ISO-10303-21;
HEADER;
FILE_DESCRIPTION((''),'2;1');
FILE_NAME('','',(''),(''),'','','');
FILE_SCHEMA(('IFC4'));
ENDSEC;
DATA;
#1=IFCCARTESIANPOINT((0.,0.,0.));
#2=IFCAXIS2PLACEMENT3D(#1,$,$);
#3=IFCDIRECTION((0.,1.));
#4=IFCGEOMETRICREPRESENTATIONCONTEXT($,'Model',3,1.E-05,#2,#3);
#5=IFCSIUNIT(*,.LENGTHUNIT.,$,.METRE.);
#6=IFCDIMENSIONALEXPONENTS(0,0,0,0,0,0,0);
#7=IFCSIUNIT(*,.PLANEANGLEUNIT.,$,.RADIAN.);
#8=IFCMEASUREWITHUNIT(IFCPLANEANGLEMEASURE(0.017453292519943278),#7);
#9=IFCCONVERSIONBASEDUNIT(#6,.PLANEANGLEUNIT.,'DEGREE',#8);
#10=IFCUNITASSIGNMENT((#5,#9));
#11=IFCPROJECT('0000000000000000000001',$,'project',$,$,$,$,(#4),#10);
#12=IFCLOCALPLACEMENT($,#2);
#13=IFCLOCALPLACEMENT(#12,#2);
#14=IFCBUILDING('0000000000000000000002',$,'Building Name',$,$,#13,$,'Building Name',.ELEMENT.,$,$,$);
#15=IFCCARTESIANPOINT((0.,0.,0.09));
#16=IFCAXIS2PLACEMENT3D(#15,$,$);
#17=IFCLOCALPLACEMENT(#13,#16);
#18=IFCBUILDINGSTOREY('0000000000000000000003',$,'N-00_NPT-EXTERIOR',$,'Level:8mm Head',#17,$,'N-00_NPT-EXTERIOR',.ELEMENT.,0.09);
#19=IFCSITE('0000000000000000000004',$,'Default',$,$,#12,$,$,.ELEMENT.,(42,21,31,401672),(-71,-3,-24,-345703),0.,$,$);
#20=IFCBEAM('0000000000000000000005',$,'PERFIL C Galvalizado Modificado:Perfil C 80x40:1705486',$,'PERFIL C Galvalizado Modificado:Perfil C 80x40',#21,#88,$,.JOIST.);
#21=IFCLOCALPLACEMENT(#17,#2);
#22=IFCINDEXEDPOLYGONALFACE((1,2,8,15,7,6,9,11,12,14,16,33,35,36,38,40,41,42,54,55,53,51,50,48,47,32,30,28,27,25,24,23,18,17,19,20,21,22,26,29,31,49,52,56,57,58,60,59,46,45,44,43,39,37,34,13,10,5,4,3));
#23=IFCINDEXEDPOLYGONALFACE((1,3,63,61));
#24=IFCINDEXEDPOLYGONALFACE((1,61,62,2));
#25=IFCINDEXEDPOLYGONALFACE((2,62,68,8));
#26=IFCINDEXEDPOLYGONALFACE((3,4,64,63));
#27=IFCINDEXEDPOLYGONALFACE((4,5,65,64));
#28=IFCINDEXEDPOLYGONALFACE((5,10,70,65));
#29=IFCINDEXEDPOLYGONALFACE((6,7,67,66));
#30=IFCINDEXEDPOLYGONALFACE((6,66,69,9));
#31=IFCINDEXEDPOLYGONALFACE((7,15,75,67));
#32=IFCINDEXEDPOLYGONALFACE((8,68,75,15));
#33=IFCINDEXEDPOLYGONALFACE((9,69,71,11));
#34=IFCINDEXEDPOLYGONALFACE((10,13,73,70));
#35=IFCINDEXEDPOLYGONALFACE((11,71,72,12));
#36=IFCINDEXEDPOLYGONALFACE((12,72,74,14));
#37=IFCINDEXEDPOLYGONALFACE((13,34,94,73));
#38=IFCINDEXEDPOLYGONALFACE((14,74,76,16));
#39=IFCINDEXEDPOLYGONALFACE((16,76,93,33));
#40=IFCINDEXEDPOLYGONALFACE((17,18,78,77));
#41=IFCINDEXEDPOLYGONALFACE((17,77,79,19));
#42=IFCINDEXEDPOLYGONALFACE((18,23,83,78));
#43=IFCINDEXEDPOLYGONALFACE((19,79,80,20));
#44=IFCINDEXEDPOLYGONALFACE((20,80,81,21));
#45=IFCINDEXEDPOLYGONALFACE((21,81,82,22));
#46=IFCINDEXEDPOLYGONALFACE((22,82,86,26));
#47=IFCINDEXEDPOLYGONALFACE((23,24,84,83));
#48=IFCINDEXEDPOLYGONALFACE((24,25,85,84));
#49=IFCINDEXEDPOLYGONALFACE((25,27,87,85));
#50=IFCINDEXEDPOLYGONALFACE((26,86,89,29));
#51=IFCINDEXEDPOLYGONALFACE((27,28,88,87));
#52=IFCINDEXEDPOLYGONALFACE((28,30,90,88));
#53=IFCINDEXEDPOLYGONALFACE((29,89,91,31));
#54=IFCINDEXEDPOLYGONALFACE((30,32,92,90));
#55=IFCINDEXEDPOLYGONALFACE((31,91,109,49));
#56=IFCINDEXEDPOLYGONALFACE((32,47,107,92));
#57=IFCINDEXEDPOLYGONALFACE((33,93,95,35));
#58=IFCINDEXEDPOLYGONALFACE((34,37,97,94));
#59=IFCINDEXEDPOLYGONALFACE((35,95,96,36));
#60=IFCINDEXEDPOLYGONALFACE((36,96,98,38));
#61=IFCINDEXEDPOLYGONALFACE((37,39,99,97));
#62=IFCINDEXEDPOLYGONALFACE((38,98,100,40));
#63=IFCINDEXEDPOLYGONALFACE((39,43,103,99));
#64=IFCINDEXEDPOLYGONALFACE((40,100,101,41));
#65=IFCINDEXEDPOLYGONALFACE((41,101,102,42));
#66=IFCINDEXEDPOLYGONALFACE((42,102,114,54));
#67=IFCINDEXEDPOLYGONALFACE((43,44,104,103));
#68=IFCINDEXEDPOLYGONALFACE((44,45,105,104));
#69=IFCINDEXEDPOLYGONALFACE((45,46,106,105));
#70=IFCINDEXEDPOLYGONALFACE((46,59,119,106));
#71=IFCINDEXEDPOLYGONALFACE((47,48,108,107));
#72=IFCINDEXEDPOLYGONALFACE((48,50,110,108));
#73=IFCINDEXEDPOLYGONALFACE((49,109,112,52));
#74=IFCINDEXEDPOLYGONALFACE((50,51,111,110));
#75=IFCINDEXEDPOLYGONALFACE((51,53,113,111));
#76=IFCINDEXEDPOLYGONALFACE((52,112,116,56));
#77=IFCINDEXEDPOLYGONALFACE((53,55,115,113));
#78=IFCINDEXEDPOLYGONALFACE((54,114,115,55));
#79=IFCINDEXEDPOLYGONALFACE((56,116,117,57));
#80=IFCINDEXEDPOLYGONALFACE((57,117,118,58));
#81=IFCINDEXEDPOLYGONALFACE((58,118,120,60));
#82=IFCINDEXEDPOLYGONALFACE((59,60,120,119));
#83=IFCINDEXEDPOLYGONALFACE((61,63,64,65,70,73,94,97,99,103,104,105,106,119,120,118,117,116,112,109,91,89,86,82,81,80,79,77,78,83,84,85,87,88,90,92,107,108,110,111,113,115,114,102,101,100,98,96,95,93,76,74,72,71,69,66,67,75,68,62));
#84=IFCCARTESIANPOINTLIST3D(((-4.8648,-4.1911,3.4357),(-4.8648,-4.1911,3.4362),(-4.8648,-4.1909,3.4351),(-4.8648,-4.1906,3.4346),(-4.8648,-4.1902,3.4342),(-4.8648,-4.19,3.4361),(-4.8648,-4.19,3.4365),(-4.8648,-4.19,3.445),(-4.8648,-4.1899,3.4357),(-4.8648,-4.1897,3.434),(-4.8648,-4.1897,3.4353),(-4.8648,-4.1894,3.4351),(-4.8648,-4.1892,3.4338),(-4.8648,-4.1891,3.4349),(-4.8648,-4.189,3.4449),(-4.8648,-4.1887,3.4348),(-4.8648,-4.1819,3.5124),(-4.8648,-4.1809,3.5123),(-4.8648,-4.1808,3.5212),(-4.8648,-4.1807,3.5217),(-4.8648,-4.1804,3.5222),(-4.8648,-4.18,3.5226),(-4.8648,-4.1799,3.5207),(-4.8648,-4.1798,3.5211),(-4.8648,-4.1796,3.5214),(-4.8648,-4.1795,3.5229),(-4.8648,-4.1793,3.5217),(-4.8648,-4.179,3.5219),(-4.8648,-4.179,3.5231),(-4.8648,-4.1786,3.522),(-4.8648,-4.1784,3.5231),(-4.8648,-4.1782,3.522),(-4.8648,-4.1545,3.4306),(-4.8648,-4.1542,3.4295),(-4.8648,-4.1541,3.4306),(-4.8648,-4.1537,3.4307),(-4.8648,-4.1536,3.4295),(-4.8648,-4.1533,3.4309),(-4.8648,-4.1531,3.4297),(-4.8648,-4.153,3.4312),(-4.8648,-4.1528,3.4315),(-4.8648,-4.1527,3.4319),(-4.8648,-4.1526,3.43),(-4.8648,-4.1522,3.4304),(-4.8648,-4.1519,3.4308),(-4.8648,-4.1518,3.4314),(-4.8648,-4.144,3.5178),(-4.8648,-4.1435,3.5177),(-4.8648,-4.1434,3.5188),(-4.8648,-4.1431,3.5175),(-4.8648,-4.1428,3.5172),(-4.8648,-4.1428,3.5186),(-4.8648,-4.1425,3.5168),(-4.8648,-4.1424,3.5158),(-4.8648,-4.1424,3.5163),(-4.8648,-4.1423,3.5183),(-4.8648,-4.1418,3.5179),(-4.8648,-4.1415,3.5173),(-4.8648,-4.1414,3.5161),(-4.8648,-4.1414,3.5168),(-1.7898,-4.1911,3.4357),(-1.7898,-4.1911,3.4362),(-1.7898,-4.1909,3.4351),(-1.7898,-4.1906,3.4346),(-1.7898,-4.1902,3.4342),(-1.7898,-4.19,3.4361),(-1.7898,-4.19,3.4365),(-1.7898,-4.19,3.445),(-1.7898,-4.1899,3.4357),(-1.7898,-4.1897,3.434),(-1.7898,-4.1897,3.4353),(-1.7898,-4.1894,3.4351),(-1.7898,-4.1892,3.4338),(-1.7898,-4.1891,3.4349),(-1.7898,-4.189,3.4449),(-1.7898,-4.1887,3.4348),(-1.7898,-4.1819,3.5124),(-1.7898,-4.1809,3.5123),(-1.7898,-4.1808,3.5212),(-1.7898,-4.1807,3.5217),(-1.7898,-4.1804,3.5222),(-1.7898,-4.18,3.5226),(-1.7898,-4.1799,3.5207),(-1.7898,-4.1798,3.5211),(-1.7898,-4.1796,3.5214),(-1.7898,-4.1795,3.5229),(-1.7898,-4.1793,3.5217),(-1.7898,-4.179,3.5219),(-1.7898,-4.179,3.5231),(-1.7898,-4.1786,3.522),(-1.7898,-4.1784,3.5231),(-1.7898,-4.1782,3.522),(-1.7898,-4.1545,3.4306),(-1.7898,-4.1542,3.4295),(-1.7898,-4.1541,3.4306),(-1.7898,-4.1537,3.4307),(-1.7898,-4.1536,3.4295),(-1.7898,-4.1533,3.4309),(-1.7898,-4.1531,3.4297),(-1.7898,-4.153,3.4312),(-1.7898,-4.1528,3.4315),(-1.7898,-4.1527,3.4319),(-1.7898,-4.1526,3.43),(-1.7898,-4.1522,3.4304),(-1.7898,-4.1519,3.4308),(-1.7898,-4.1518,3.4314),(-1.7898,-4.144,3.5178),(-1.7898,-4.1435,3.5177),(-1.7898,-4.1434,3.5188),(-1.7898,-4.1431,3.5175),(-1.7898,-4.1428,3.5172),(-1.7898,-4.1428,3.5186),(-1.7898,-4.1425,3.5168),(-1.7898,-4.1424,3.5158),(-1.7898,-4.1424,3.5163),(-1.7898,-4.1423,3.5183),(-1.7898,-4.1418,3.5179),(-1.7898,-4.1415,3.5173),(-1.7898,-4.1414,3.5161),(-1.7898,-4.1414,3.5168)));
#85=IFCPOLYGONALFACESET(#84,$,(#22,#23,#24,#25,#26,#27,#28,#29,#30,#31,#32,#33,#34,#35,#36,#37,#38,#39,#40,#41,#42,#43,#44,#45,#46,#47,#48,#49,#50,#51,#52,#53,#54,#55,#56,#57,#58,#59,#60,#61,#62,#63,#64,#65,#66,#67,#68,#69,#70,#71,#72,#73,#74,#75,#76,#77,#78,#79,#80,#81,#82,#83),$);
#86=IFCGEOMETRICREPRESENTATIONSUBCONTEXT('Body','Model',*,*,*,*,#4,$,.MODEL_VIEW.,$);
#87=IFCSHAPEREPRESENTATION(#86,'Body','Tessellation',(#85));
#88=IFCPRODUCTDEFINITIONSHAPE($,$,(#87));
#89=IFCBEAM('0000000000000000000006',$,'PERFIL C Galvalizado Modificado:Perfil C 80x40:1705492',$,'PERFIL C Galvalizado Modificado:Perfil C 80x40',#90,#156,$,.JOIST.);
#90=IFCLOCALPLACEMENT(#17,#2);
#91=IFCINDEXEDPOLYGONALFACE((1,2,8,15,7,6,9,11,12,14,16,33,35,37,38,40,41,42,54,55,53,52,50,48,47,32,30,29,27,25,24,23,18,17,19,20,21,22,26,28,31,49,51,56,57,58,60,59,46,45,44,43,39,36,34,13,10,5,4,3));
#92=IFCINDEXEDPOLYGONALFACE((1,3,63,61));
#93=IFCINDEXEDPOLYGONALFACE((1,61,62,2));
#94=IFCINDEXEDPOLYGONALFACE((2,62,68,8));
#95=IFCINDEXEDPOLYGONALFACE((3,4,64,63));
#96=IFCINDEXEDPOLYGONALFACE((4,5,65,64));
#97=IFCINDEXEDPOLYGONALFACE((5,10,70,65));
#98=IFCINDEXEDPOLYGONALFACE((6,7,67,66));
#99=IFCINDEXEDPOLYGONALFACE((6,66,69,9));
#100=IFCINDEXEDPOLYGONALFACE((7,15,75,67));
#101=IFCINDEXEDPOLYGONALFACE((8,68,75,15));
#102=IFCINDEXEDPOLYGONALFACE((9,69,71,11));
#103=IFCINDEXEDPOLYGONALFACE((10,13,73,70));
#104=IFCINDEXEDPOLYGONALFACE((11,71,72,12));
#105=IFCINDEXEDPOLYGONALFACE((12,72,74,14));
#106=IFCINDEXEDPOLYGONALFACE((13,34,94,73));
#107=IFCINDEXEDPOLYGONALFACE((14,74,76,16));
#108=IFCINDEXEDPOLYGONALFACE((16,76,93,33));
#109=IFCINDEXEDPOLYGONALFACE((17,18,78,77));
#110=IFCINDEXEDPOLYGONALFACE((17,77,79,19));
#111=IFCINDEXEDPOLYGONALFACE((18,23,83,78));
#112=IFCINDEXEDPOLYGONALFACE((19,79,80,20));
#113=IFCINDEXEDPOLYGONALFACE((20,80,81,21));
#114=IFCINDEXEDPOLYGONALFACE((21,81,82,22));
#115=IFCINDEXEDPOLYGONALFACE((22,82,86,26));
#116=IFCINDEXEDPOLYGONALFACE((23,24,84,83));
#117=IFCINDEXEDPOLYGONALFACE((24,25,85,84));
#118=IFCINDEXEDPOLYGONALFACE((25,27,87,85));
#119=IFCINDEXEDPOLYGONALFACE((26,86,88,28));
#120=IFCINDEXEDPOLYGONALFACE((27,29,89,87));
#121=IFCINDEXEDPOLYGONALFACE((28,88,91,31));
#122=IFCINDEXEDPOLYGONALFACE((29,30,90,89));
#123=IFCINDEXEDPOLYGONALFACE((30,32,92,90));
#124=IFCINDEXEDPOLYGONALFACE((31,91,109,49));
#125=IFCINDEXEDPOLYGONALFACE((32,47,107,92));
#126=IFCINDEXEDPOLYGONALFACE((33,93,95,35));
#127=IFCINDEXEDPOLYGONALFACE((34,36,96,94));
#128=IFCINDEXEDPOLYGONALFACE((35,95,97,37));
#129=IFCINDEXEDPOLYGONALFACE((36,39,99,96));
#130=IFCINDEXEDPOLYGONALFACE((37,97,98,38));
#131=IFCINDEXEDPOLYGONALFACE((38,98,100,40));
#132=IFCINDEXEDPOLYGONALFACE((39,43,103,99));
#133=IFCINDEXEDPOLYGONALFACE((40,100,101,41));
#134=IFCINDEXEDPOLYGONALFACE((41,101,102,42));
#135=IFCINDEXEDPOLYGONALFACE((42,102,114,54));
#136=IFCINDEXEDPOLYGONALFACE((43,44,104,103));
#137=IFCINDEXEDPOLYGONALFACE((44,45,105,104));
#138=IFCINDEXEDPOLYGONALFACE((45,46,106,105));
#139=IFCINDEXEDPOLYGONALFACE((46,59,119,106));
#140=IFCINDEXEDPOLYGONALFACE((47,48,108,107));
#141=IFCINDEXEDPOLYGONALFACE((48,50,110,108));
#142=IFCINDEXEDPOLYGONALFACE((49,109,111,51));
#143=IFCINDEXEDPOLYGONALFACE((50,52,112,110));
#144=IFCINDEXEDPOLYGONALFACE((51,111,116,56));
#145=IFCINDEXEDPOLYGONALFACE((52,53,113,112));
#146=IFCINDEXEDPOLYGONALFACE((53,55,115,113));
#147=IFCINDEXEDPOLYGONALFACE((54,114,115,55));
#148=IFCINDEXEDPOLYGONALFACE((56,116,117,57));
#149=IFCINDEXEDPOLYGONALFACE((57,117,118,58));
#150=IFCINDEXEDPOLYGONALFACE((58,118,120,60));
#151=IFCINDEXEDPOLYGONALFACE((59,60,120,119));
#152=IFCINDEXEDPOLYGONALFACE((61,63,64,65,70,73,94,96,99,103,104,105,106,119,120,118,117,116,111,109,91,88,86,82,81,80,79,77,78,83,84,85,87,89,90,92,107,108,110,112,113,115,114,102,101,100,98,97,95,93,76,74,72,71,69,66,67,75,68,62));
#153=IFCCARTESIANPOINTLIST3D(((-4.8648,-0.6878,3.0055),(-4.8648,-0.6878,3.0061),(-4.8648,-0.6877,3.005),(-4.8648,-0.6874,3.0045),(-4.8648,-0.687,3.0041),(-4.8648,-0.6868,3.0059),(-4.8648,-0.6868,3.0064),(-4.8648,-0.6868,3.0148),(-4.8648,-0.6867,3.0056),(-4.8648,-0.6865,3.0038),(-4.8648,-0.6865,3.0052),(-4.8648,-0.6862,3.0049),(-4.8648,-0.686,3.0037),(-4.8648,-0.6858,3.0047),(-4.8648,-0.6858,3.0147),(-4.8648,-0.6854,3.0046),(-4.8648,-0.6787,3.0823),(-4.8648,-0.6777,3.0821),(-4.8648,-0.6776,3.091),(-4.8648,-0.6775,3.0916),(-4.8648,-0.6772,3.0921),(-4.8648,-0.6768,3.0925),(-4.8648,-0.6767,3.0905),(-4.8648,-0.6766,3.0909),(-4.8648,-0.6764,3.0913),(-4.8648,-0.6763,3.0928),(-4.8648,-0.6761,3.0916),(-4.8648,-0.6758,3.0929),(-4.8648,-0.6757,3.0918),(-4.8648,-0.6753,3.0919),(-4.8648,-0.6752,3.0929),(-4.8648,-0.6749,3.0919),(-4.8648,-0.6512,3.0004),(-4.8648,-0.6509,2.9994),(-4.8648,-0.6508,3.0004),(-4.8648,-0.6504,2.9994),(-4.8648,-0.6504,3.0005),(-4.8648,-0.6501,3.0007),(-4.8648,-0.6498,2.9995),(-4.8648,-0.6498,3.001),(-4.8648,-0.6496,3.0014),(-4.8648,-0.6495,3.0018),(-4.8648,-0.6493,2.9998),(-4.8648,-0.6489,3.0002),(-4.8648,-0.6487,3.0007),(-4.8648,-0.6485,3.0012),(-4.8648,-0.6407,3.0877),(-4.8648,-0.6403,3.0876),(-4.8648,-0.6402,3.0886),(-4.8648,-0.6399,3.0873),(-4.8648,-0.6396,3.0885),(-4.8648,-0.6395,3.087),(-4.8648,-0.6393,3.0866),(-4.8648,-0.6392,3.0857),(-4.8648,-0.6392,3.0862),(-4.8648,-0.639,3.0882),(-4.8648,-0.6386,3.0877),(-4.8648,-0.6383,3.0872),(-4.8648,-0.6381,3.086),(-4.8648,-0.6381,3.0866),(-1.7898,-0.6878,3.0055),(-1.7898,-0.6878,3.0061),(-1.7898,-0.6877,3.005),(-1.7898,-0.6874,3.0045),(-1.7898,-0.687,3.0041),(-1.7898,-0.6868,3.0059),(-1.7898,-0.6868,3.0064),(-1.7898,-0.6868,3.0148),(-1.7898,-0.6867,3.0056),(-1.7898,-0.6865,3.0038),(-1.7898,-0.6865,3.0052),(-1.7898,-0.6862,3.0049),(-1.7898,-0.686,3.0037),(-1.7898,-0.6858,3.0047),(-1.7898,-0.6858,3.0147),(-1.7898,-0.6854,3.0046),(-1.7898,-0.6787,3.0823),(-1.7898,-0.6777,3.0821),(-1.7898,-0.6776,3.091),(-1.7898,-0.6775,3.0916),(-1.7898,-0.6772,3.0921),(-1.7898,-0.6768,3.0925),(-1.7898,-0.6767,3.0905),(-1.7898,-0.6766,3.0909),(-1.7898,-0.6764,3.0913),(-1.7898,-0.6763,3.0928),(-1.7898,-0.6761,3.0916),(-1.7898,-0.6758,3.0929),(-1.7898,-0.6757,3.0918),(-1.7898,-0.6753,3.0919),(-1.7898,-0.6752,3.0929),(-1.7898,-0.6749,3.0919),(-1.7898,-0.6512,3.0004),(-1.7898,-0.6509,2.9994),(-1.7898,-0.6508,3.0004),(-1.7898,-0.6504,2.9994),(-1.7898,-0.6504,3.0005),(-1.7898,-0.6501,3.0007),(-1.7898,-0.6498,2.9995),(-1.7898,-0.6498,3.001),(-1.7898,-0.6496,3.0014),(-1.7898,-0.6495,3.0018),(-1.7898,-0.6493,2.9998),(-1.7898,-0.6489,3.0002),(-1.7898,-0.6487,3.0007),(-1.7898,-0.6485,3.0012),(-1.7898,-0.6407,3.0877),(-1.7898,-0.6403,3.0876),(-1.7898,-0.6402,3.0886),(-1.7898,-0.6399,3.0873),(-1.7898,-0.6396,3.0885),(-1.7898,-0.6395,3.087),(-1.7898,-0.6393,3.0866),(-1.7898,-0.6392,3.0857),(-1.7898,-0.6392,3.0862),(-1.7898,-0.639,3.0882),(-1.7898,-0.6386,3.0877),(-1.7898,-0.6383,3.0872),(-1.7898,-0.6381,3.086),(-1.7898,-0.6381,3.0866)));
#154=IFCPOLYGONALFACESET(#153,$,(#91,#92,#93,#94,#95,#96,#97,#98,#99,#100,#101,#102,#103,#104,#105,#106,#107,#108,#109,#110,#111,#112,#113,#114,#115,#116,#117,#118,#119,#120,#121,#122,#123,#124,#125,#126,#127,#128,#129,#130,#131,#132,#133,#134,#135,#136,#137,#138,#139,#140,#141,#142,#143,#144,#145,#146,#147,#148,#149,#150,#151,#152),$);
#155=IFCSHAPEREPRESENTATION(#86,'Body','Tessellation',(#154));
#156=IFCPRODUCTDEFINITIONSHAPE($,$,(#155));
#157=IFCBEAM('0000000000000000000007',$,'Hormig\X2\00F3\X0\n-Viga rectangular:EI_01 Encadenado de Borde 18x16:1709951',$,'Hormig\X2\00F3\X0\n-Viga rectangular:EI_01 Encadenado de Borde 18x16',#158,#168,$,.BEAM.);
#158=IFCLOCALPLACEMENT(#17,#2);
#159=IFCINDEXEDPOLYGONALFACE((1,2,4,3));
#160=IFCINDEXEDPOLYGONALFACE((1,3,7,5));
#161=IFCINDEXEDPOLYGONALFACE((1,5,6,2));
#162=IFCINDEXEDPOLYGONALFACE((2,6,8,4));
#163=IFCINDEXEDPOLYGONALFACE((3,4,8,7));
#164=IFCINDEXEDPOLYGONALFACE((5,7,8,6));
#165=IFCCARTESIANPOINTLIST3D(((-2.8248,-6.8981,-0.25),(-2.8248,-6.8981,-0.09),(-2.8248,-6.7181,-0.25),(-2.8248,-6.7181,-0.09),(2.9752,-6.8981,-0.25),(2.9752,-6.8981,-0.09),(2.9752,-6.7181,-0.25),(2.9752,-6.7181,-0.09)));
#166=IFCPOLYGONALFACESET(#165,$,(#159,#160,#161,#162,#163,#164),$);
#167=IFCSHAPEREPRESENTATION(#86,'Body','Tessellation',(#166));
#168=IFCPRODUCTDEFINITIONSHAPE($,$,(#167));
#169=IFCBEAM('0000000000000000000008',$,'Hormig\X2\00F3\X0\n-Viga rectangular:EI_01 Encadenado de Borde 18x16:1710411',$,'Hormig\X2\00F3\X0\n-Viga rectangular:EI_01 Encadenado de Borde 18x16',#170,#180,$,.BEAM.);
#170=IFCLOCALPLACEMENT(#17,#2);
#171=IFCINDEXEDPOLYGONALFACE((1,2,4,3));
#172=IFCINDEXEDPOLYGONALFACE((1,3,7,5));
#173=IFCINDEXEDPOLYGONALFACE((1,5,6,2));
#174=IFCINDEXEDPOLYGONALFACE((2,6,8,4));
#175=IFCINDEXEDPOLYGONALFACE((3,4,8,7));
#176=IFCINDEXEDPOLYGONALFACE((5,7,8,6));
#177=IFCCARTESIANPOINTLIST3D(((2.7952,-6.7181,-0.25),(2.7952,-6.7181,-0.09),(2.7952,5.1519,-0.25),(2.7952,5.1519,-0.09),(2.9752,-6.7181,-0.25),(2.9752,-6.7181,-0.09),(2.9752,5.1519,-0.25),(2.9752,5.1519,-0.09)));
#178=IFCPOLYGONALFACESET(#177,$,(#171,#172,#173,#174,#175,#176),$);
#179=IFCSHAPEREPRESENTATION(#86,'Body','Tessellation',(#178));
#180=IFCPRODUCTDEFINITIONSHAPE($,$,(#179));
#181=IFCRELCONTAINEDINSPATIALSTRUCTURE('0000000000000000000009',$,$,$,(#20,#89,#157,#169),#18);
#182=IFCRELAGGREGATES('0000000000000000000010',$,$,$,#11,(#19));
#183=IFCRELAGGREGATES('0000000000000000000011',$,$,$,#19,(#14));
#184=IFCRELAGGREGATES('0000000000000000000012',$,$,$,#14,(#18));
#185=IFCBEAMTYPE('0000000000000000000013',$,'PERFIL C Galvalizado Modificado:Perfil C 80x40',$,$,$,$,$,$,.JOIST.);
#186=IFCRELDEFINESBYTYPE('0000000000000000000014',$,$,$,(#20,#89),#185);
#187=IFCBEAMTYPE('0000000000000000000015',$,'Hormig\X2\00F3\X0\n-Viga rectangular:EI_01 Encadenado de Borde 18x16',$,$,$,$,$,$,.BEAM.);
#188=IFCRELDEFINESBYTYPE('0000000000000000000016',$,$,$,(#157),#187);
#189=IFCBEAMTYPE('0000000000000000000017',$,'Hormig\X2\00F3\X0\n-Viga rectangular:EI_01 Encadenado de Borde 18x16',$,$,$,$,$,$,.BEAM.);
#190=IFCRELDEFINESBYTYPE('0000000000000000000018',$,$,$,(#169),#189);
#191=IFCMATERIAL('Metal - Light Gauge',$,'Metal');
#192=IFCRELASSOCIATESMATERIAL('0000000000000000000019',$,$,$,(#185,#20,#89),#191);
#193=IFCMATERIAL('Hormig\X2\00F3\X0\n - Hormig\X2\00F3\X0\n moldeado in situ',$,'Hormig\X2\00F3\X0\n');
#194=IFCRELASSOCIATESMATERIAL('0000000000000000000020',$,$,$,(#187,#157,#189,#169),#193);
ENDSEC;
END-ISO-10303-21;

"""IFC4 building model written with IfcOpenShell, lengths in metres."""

from ifc_helpers import new_model, entity, si_unit, converted_unit, direction, frame, origin, place, context, subcontext, project, spatial, line, arc, indexed_curve, outline, extrude, source, transform, mapped, material, type_object, type_shapes, element, save


model = new_model("IFC4")

# Units and contexts
model_context = context("Model", 3, precision=1e-05, world=origin(), true_north=direction((0.0, 1.0)))
body_context = subcontext(model_context, "Body", "Model", "MODEL_VIEW")
ifc_project = project(units=[si_unit("LENGTHUNIT", "METRE"), converted_unit("PLANEANGLEUNIT", "DEGREE", entity("IfcPlaneAngleMeasure", 0.017453292519943278), si_unit("PLANEANGLEUNIT", "RADIAN"), dimensions=[0, 0, 0, 0, 0, 0, 0])], contexts=[model_context])

# Site, building, storey
site_placement = place(None, origin())
site = spatial("IfcSite", under=ifc_project, at=site_placement, Name="Default", CompositionType="ELEMENT", RefLatitude=(42, 21, 31, 401672), RefLongitude=(-71, -3, -24, -345703), RefElevation=0.0)
building_placement = place(site_placement, origin())
building = spatial("IfcBuilding", under=site, at=building_placement, Name="Building Name", LongName="Building Name", CompositionType="ELEMENT")
storey_placement = place(building_placement, frame((0.0, 0.0, 0.09)))
storey = spatial("IfcBuildingStorey", under=building, at=storey_placement, Name="N-00_NPT-EXTERIOR", ObjectType="Level:8mm Head", LongName="N-00_NPT-EXTERIOR", CompositionType="ELEMENT", Elevation=0.09)

# Beams
ifc_material_1 = material(Name="Hormigón - Hormigón moldeado in situ", Category="Hormigón")
ifc_material_2 = material(Name="Metal - Light Gauge", Category="Metal")
beam_type_1 = type_object("IfcBeamType", Name="PERFIL C Galvalizado Modificado:Perfil C 80x40", PredefinedType="JOIST", material=ifc_material_2)
shared_shape_1 = source(origin(), body_context, "Body", "SweptSolid", [
    extrude(outline(indexed_curve([(-0.0428, -0.0237), (0.0426, -0.0237), (0.0443, -0.023), (0.045, -0.0214), (0.045, 0.0139), (0.0443, 0.0154), (0.0428, 0.0161), (0.034, 0.0161), (0.034, 0.0151), (0.0424, 0.0151), (0.0435, 0.0146), (0.044, 0.0135), (0.044, -0.021), (0.0435, -0.0222), (0.0422, -0.0227), (-0.0424, -0.0227), (-0.0435, -0.0223), (-0.0439, -0.0212), (-0.0439, 0.0133), (-0.0435, 0.0144), (-0.0424, 0.0149), (-0.0339, 0.0149), (-0.0339, 0.0159), (-0.0428, 0.0159), (-0.0443, 0.0152), (-0.0449, 0.0137), (-0.0449, -0.0216), (-0.0443, -0.0231)], segments=[line(1, 2), arc(2, 3, 4), line(4, 5), arc(5, 6, 7), line(7, 8, 9, 10), arc(10, 11, 12), line(12, 13), arc(13, 14, 15), line(15, 16), arc(16, 17, 18), line(18, 19), arc(19, 20, 21), line(21, 22, 23, 24), arc(24, 25, 26), line(26, 27), arc(27, 28, 1)], self_intersect=False)), frame((-1.5375, -0.0037, 0.0), z_axis=(1.0, 0.0, 0.0), x_axis=(0.0, 0.0, 1.0)), (0.0, 0.0, 1.0), 3.075),
])
type_shapes(beam_type_1, [shared_shape_1])
for number, where, z_axis, x_axis, name in (
    (1, (-3.3273, -4.1664, 3.4763), (0.0, 0.121869, 0.992546), (1.0, 0.0, 0.0), "PERFIL C Galvalizado Modificado:Perfil C 80x40:1705486"),
    (2, (-3.3273, -0.6632, 3.0462), (0.0, 0.121869, 0.992546), (1.0, 0.0, 0.0), "PERFIL C Galvalizado Modificado:Perfil C 80x40:1705492"),
):
    element("IfcBeam", number, at=place(storey_placement, frame(where, z_axis=z_axis, x_axis=x_axis)), inside=storey, type_object=beam_type_1, material=ifc_material_2, Name=name, ObjectType="PERFIL C Galvalizado Modificado:Perfil C 80x40", PredefinedType="JOIST", context=body_context, shape_type="MappedRepresentation", body=[
        mapped(shared_shape_1, transform((0.0, 0.0, 0.0), scale=1.0)),
    ])
beam_type_2 = type_object("IfcBeamType", Name="Hormigón-Viga rectangular:EI_01 Encadenado de Borde 18x16", PredefinedType="BEAM", material=ifc_material_1)
shared_shape_2 = source(origin(), body_context, "Body", "SweptSolid", [
    extrude(outline(indexed_curve([(-0.08, -0.09), (0.08, -0.09), (0.08, 0.09), (-0.08, 0.09), (-0.08, -0.09)], self_intersect=False)), frame((2.9752, -6.8081, -0.08), z_axis=(-1.0, 0.0, 0.0), x_axis=(0.0, 0.0, -1.0)), (0.0, 0.0, 1.0), 5.8),
])
type_shapes(beam_type_2, [shared_shape_2])
beam_1_placement = place(storey_placement, frame((0.0, 0.0, -0.09)))
element("IfcBeam", 3, at=beam_1_placement, inside=storey, type_object=beam_type_2, material=ifc_material_1, Name="Hormigón-Viga rectangular:EI_01 Encadenado de Borde 18x16:1709951", ObjectType="Hormigón-Viga rectangular:EI_01 Encadenado de Borde 18x16", PredefinedType="BEAM", context=body_context, shape_type="MappedRepresentation", body=[
    mapped(shared_shape_2, transform((0.0, 0.0, 0.0), scale=1.0)),
])
beam_type_3 = type_object("IfcBeamType", Name="Hormigón-Viga rectangular:EI_01 Encadenado de Borde 18x16", PredefinedType="BEAM", material=ifc_material_1)
shared_shape_3 = source(origin(), body_context, "Body", "SweptSolid", [
    extrude(outline(indexed_curve([(-0.09, -0.08), (0.09, -0.08), (0.09, 0.08), (-0.09, 0.08), (-0.09, -0.08)], self_intersect=False)), frame((2.8852, -6.7181, -0.08), z_axis=(0.0, 1.0, 0.0), x_axis=(-1.0, 0.0, 0.0)), (0.0, 0.0, 1.0), 11.87),
])
type_shapes(beam_type_3, [shared_shape_3])
beam_2_placement = place(storey_placement, frame((0.0, 0.0, -0.09)))
element("IfcBeam", 4, at=beam_2_placement, inside=storey, type_object=beam_type_3, material=ifc_material_1, Name="Hormigón-Viga rectangular:EI_01 Encadenado de Borde 18x16:1710411", ObjectType="Hormigón-Viga rectangular:EI_01 Encadenado de Borde 18x16", PredefinedType="BEAM", context=body_context, shape_type="MappedRepresentation", body=[
    mapped(shared_shape_3, transform((0.0, 0.0, 0.0), scale=1.0)),
])

save(model, "model.ifc")
